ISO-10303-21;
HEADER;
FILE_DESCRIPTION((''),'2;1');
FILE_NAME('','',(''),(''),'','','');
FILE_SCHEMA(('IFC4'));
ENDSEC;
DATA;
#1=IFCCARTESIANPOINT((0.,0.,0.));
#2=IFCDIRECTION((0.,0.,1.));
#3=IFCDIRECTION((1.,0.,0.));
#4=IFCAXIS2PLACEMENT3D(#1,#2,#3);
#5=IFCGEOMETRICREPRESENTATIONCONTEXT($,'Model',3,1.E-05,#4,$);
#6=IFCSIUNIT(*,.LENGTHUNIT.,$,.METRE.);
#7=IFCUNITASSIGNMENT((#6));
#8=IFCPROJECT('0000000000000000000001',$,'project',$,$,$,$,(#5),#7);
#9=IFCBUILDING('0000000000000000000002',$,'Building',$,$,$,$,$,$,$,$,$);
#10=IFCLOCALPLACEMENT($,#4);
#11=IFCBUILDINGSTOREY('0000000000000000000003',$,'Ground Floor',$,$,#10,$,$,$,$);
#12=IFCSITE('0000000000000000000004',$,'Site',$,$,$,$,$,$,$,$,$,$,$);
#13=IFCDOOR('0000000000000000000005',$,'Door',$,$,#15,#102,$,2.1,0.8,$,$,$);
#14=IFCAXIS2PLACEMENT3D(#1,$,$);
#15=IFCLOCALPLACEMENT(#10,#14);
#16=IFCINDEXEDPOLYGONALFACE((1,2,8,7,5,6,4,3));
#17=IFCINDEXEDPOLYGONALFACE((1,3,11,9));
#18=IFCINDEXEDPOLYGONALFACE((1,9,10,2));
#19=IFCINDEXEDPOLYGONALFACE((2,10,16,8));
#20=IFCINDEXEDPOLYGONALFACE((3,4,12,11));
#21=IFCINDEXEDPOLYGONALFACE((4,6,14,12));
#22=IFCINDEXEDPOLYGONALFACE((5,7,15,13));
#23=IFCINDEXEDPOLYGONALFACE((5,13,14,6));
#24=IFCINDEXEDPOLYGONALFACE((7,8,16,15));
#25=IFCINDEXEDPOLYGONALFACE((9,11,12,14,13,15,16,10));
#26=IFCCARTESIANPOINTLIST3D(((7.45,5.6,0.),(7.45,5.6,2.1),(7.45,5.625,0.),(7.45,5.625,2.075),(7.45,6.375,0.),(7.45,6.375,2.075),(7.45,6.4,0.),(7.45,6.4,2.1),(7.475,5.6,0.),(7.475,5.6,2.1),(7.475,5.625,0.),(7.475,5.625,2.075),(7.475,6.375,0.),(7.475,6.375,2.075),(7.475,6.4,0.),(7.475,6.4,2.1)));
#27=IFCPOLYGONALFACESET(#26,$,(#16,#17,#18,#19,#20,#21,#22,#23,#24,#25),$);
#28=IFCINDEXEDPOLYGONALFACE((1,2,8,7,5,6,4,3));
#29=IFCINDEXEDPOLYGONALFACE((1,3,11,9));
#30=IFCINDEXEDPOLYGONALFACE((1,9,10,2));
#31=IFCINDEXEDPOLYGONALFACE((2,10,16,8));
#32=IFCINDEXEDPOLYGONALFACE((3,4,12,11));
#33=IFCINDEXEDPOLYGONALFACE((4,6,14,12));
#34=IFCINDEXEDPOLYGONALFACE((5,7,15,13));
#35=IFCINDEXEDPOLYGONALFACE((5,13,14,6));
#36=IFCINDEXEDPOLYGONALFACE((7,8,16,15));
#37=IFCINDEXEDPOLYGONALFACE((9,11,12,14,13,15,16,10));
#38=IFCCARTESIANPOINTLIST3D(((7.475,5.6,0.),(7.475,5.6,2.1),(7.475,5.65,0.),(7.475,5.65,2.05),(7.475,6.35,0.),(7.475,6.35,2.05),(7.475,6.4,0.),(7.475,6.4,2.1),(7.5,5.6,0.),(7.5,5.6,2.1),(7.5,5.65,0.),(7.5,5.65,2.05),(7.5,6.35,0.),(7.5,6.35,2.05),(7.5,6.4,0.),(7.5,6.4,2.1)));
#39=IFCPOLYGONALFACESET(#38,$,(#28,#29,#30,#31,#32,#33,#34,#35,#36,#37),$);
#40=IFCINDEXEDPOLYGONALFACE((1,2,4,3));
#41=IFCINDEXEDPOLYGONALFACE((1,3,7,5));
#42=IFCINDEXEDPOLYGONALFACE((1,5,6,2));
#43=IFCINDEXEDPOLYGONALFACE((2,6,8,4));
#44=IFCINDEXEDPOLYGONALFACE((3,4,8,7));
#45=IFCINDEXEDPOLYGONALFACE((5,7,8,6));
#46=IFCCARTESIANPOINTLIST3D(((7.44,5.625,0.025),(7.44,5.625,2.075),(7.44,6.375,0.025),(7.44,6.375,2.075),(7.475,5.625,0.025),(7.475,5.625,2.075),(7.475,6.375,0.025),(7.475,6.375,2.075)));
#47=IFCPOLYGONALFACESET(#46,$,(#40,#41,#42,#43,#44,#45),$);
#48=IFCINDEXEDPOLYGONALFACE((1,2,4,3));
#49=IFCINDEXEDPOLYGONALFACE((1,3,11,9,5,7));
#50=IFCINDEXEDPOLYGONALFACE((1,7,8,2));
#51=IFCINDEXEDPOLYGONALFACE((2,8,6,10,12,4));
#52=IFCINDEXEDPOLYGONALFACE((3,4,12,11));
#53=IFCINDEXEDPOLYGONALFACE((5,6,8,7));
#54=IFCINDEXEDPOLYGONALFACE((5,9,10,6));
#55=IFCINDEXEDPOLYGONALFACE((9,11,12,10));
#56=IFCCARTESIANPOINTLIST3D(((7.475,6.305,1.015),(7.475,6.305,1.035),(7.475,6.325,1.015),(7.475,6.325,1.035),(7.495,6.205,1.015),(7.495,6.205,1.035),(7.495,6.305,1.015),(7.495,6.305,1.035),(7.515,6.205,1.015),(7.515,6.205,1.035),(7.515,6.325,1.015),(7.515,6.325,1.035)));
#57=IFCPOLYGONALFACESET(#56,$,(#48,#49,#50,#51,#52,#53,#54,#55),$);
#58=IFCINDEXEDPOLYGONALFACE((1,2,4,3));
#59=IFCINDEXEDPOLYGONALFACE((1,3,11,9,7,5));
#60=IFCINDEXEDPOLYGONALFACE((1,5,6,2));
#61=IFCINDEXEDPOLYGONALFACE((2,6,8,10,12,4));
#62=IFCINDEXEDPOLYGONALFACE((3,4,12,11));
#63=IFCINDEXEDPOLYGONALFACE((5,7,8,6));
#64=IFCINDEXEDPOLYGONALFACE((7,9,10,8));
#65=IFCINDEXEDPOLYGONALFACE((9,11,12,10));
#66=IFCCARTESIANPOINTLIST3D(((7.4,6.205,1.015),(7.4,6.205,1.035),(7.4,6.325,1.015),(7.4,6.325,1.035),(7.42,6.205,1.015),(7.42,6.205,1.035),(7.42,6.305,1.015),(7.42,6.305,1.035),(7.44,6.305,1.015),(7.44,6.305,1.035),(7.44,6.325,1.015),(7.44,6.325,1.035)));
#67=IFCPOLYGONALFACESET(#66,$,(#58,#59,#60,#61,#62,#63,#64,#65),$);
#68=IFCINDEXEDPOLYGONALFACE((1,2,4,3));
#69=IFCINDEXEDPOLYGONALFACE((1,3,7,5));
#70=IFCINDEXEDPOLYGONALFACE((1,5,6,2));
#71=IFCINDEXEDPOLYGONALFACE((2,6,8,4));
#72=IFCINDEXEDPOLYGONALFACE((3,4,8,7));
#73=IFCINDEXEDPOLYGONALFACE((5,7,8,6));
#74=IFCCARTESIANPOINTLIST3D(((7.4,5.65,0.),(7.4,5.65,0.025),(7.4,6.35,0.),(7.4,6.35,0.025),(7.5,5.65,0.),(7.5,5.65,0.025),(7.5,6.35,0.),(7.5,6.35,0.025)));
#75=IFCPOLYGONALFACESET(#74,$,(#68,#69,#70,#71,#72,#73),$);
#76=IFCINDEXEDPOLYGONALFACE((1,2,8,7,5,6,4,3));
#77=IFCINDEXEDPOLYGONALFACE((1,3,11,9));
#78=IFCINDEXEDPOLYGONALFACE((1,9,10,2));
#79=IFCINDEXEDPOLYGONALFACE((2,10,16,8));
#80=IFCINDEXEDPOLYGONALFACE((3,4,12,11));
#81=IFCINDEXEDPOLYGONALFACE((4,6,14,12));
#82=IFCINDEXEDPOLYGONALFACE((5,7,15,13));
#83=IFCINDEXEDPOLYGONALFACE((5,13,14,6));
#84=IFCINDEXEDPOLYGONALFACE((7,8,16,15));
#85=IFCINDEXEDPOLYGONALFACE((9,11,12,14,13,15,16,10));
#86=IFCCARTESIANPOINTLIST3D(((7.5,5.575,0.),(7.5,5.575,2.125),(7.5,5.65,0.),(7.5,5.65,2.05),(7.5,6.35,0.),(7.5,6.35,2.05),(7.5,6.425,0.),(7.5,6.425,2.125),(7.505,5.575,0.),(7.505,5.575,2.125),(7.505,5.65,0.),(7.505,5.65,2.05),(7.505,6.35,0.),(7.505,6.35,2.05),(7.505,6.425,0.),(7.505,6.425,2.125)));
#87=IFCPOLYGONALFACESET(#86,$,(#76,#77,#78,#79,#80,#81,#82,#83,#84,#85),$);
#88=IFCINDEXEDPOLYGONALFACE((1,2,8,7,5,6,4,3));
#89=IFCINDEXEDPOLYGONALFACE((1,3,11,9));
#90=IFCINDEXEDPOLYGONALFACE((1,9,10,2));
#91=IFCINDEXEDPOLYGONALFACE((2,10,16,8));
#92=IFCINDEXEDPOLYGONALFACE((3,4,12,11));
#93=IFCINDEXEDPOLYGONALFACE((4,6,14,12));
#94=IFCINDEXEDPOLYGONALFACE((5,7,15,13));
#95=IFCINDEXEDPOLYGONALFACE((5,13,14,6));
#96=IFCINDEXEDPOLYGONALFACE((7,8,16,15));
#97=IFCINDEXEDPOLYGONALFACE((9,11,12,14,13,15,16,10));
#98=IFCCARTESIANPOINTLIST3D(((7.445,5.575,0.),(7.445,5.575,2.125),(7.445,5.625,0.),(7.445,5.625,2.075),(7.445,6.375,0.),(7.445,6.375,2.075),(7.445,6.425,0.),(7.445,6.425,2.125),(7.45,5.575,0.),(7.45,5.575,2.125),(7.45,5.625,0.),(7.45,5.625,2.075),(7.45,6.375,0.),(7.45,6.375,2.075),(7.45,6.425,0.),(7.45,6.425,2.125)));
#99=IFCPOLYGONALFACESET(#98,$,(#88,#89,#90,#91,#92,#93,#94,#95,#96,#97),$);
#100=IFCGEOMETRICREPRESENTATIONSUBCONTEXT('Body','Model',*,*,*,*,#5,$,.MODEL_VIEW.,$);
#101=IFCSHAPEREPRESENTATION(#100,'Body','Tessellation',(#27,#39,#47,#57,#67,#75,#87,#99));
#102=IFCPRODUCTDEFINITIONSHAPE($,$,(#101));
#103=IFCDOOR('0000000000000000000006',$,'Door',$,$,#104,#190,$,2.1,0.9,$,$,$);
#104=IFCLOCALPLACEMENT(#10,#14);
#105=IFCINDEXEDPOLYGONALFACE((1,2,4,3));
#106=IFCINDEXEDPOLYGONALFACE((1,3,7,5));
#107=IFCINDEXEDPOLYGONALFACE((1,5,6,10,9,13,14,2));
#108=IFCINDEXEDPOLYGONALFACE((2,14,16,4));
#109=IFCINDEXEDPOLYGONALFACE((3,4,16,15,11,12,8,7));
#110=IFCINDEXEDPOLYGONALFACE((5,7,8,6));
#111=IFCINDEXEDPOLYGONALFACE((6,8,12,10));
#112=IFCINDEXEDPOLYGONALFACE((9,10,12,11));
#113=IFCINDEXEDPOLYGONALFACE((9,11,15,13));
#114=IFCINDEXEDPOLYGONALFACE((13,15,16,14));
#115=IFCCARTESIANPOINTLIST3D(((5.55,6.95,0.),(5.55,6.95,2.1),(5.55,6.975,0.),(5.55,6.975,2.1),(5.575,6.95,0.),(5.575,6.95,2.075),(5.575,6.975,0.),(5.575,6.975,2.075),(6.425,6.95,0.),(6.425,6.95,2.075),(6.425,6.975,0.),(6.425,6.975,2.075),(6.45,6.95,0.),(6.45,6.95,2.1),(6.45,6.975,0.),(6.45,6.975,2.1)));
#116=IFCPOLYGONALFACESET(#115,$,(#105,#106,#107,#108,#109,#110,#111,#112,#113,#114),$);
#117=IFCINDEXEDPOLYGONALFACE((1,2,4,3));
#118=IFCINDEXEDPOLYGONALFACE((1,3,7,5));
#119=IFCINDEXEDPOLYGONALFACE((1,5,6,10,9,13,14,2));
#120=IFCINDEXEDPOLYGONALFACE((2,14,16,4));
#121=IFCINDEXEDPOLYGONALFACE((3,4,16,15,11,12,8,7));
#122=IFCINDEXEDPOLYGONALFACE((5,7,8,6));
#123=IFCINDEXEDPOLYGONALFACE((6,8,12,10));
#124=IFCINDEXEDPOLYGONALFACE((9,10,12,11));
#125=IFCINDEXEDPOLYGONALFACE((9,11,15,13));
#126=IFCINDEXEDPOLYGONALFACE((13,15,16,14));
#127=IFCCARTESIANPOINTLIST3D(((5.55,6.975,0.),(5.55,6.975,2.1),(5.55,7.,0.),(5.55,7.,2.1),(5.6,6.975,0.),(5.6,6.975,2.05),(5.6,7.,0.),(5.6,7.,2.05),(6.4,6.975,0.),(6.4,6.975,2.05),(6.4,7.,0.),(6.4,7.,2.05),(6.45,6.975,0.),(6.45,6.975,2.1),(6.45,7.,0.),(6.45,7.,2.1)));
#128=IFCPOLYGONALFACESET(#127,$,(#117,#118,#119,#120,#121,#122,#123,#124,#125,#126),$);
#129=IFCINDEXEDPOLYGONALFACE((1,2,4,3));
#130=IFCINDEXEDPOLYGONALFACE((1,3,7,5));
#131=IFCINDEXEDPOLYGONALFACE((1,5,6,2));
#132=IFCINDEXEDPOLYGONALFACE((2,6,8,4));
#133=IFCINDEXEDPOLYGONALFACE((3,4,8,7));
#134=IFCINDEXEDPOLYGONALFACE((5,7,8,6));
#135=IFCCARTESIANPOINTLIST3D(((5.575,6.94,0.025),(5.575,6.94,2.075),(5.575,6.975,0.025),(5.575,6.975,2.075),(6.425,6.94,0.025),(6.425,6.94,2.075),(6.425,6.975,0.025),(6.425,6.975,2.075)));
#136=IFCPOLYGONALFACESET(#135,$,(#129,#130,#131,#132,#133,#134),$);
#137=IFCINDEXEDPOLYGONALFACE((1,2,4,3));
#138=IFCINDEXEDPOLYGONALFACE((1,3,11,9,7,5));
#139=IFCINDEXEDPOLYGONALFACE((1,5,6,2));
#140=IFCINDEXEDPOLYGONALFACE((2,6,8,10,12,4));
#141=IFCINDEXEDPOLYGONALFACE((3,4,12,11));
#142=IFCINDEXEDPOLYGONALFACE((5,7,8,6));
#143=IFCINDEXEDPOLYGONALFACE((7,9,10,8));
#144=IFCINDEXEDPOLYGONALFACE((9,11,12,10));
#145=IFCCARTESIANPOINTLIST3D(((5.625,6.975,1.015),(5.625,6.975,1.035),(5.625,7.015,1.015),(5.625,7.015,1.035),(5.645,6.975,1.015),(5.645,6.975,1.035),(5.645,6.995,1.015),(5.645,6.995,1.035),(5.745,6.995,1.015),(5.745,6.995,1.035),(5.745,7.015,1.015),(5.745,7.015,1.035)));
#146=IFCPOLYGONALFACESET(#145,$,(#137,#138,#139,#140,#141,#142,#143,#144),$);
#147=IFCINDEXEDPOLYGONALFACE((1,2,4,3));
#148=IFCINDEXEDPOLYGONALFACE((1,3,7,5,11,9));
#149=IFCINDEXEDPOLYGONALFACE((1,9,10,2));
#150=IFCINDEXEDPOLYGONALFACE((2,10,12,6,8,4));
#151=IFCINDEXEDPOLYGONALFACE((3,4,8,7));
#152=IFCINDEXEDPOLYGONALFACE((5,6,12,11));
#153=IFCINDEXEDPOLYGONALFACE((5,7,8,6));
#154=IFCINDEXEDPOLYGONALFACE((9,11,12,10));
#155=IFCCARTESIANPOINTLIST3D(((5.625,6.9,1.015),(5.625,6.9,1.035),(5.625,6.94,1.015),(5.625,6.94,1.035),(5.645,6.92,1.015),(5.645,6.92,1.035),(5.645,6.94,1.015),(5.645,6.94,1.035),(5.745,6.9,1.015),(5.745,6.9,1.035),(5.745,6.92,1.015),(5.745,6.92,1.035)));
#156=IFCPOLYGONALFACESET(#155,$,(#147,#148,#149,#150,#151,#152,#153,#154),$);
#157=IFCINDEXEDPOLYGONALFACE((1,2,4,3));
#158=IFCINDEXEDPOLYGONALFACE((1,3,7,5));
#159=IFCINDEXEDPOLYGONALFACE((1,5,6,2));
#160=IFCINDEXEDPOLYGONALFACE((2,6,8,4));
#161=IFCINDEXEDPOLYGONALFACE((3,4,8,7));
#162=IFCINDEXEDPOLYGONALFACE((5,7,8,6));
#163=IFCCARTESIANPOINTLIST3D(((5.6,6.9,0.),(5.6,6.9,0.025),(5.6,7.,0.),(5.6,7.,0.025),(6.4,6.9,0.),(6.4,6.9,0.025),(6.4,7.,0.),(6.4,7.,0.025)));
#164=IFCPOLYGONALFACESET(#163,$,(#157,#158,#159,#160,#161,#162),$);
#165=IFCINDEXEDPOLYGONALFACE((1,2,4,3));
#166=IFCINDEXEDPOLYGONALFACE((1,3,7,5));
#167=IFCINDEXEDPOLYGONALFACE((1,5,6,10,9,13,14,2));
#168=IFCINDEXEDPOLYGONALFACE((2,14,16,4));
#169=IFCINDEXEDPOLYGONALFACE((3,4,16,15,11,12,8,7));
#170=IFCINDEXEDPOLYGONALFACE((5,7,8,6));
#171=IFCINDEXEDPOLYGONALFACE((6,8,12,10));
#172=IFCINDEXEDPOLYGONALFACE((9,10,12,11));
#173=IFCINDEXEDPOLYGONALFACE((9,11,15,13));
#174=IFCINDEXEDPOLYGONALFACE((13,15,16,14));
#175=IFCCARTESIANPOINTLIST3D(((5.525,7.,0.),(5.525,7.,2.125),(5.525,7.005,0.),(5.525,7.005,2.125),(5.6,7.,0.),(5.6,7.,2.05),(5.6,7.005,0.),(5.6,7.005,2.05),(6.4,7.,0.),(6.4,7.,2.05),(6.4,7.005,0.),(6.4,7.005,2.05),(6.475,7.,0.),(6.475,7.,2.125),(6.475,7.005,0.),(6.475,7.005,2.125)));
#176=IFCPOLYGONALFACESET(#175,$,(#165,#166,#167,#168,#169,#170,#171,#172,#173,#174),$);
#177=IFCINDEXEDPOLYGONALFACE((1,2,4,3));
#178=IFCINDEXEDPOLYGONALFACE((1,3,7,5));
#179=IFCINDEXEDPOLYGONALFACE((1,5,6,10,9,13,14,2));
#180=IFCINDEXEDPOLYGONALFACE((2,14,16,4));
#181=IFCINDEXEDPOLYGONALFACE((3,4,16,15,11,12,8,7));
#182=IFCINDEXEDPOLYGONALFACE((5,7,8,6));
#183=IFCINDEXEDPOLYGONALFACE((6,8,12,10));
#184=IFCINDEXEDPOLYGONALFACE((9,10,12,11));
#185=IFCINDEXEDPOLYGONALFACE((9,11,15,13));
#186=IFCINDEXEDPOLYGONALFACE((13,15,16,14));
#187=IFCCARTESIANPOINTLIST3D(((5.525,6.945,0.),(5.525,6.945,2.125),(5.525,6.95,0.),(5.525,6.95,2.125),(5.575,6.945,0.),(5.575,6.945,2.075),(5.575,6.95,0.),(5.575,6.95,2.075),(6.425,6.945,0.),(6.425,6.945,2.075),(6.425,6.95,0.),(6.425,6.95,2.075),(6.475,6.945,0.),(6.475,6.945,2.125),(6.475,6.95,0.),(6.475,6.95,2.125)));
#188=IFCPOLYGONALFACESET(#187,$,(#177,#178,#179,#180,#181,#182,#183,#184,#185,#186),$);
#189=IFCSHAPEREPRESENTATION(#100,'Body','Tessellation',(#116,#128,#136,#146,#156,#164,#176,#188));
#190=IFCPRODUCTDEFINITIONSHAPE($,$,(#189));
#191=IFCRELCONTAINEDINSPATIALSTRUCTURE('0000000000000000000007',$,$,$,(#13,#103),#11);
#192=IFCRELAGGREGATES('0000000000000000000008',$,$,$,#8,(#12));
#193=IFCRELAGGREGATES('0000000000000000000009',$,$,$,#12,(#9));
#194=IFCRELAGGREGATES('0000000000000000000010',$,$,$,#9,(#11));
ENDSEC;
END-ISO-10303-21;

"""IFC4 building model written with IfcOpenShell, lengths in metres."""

from ifc_helpers import new_model, si_unit, frame, origin_with_axes, place, context, subcontext, project, spatial, line, indexed_curve, outline, extrude, element, save


model = new_model("IFC4")

# Units and contexts
model_context = context("Model", 3, precision=1e-05, world=origin_with_axes())
body_context = subcontext(model_context, "Body", "Model", "MODEL_VIEW")
ifc_project = project(units=[si_unit("LENGTHUNIT", "METRE")], contexts=[model_context])

# Site, building, storey
site = spatial("IfcSite", under=ifc_project, Name="Site")
building = spatial("IfcBuilding", under=site, Name="Building")
storey_placement = place(None, origin_with_axes())
storey = spatial("IfcBuildingStorey", under=building, at=storey_placement, Name="Ground Floor")

# Doors
door_1_placement = place(storey_placement, frame((7.5, 5.6, 0.0), z_axis=(0.0, 0.0, 1.0), x_axis=(0.0, 1.0, 0.0)))
element("IfcDoor", 1, at=door_1_placement, inside=storey, Name="Door", OverallHeight=2.1, OverallWidth=0.8, context=body_context, shape_type="SweptSolid", body=[
    extrude(outline(indexed_curve([(0.0, 0.0), (0.0, 2.1), (0.8, 2.1), (0.8, 0.0), (0.775, 0.0), (0.775, 2.075), (0.025, 2.075), (0.025, 0.0)], segments=[line(1, 2, 3, 4, 5, 6, 7, 8, 1)])), frame((0.0, 0.025, 0.0), z_axis=(0.0, -1.0, 0.0), x_axis=(1.0, 0.0, 0.0)), (0.0, 0.0, -1.0), 0.025),
    extrude(outline(indexed_curve([(0.0, 0.0), (0.0, 2.1), (0.8, 2.1), (0.8, 0.0), (0.75, 0.0), (0.75, 2.05), (0.05, 2.05), (0.05, 0.0)], segments=[line(1, 2, 3, 4, 5, 6, 7, 8, 1)])), frame((0.0, 0.0, 0.0), z_axis=(0.0, -1.0, 0.0), x_axis=(1.0, 0.0, 0.0)), (0.0, 0.0, -1.0), 0.025),
    extrude(outline(indexed_curve([(0.0, 0.0), (0.75, 0.0), (0.75, 0.035), (0.0, 0.035)], segments=[line(1, 2, 3, 4, 1)])), frame((0.025, 0.025, 0.025), z_axis=(0.0, 0.0, 1.0), x_axis=(1.0, 0.0, 0.0)), (0.0, 0.0, 1.0), 2.05),
    extrude(outline(indexed_curve([(0.0, 0.0), (0.0, -0.04), (-0.12, -0.04), (-0.12, -0.02), (-0.02, -0.02), (-0.02, 0.0)], segments=[line(1, 2, 3, 4, 5, 6, 1)])), frame((0.725, 0.025, 1.015), z_axis=(0.0, 0.0, 1.0), x_axis=(1.0, 0.0, 0.0)), (0.0, 0.0, 1.0), 0.02),
    extrude(outline(indexed_curve([(0.0, 0.0), (0.0, 0.04), (-0.12, 0.04), (-0.12, 0.02), (-0.02, 0.02), (-0.02, 0.0)], segments=[line(1, 2, 3, 4, 5, 6, 1)])), frame((0.725, 0.06, 1.015), z_axis=(0.0, 0.0, 1.0), x_axis=(1.0, 0.0, 0.0)), (0.0, 0.0, 1.0), 0.02),
    extrude(outline(indexed_curve([(0.0, 0.0), (0.7, 0.0), (0.7, 0.1), (0.0, 0.1)], segments=[line(1, 2, 3, 4, 1)])), frame((0.05, 0.0, 0.0), z_axis=(0.0, 0.0, 1.0), x_axis=(1.0, 0.0, 0.0)), (0.0, 0.0, 1.0), 0.025),
    extrude(outline(indexed_curve([(0.0, 0.0), (0.0, 2.125), (0.85, 2.125), (0.85, 0.0), (0.775, 0.0), (0.775, 2.05), (0.075, 2.05), (0.075, 0.0)], segments=[line(1, 2, 3, 4, 5, 6, 7, 8, 1)])), frame((-0.025, -0.005, 0.0), z_axis=(0.0, -1.0, 0.0), x_axis=(1.0, 0.0, 0.0)), (0.0, 0.0, -1.0), 0.005),
    extrude(outline(indexed_curve([(0.0, 0.0), (0.0, 2.125), (0.85, 2.125), (0.85, 0.0), (0.8, 0.0), (0.8, 2.075), (0.05, 2.075), (0.05, 0.0)], segments=[line(1, 2, 3, 4, 5, 6, 7, 8, 1)])), frame((-0.025, 0.05, 0.0), z_axis=(0.0, -1.0, 0.0), x_axis=(1.0, 0.0, 0.0)), (0.0, 0.0, -1.0), 0.005),
])
door_2_placement = place(storey_placement, frame((6.45, 7.0, 0.0), z_axis=(0.0, 0.0, 1.0), x_axis=(-1.0, 0.0, 0.0)))
element("IfcDoor", 2, at=door_2_placement, inside=storey, Name="Door", OverallHeight=2.1, OverallWidth=0.9, context=body_context, shape_type="SweptSolid", body=[
    extrude(outline(indexed_curve([(0.0, 0.0), (0.0, 2.1), (0.9, 2.1), (0.9, 0.0), (0.875, 0.0), (0.875, 2.075), (0.025, 2.075), (0.025, 0.0)], segments=[line(1, 2, 3, 4, 5, 6, 7, 8, 1)])), frame((0.0, 0.025, 0.0), z_axis=(0.0, -1.0, 0.0), x_axis=(1.0, 0.0, 0.0)), (0.0, 0.0, -1.0), 0.025),
    extrude(outline(indexed_curve([(0.0, 0.0), (0.0, 2.1), (0.9, 2.1), (0.9, 0.0), (0.85, 0.0), (0.85, 2.05), (0.05, 2.05), (0.05, 0.0)], segments=[line(1, 2, 3, 4, 5, 6, 7, 8, 1)])), frame((0.0, 0.0, 0.0), z_axis=(0.0, -1.0, 0.0), x_axis=(1.0, 0.0, 0.0)), (0.0, 0.0, -1.0), 0.025),
    extrude(outline(indexed_curve([(0.0, 0.0), (0.85, 0.0), (0.85, 0.035), (0.0, 0.035)], segments=[line(1, 2, 3, 4, 1)])), frame((0.025, 0.025, 0.025), z_axis=(0.0, 0.0, 1.0), x_axis=(1.0, 0.0, 0.0)), (0.0, 0.0, 1.0), 2.05),
    extrude(outline(indexed_curve([(0.0, 0.0), (0.0, -0.04), (-0.12, -0.04), (-0.12, -0.02), (-0.02, -0.02), (-0.02, 0.0)], segments=[line(1, 2, 3, 4, 5, 6, 1)])), frame((0.825, 0.025, 1.015), z_axis=(0.0, 0.0, 1.0), x_axis=(1.0, 0.0, 0.0)), (0.0, 0.0, 1.0), 0.02),
    extrude(outline(indexed_curve([(0.0, 0.0), (0.0, 0.04), (-0.12, 0.04), (-0.12, 0.02), (-0.02, 0.02), (-0.02, 0.0)], segments=[line(1, 2, 3, 4, 5, 6, 1)])), frame((0.825, 0.06, 1.015), z_axis=(0.0, 0.0, 1.0), x_axis=(1.0, 0.0, 0.0)), (0.0, 0.0, 1.0), 0.02),
    extrude(outline(indexed_curve([(0.0, 0.0), (0.8, 0.0), (0.8, 0.1), (0.0, 0.1)], segments=[line(1, 2, 3, 4, 1)])), frame((0.05, 0.0, 0.0), z_axis=(0.0, 0.0, 1.0), x_axis=(1.0, 0.0, 0.0)), (0.0, 0.0, 1.0), 0.025),
    extrude(outline(indexed_curve([(0.0, 0.0), (0.0, 2.125), (0.95, 2.125), (0.95, 0.0), (0.875, 0.0), (0.875, 2.05), (0.075, 2.05), (0.075, 0.0)], segments=[line(1, 2, 3, 4, 5, 6, 7, 8, 1)])), frame((-0.025, -0.005, 0.0), z_axis=(0.0, -1.0, 0.0), x_axis=(1.0, 0.0, 0.0)), (0.0, 0.0, -1.0), 0.005),
    extrude(outline(indexed_curve([(0.0, 0.0), (0.0, 2.125), (0.95, 2.125), (0.95, 0.0), (0.9, 0.0), (0.9, 2.075), (0.05, 2.075), (0.05, 0.0)], segments=[line(1, 2, 3, 4, 5, 6, 7, 8, 1)])), frame((-0.025, 0.05, 0.0), z_axis=(0.0, -1.0, 0.0), x_axis=(1.0, 0.0, 0.0)), (0.0, 0.0, -1.0), 0.005),
])

save(model, "model.ifc")
